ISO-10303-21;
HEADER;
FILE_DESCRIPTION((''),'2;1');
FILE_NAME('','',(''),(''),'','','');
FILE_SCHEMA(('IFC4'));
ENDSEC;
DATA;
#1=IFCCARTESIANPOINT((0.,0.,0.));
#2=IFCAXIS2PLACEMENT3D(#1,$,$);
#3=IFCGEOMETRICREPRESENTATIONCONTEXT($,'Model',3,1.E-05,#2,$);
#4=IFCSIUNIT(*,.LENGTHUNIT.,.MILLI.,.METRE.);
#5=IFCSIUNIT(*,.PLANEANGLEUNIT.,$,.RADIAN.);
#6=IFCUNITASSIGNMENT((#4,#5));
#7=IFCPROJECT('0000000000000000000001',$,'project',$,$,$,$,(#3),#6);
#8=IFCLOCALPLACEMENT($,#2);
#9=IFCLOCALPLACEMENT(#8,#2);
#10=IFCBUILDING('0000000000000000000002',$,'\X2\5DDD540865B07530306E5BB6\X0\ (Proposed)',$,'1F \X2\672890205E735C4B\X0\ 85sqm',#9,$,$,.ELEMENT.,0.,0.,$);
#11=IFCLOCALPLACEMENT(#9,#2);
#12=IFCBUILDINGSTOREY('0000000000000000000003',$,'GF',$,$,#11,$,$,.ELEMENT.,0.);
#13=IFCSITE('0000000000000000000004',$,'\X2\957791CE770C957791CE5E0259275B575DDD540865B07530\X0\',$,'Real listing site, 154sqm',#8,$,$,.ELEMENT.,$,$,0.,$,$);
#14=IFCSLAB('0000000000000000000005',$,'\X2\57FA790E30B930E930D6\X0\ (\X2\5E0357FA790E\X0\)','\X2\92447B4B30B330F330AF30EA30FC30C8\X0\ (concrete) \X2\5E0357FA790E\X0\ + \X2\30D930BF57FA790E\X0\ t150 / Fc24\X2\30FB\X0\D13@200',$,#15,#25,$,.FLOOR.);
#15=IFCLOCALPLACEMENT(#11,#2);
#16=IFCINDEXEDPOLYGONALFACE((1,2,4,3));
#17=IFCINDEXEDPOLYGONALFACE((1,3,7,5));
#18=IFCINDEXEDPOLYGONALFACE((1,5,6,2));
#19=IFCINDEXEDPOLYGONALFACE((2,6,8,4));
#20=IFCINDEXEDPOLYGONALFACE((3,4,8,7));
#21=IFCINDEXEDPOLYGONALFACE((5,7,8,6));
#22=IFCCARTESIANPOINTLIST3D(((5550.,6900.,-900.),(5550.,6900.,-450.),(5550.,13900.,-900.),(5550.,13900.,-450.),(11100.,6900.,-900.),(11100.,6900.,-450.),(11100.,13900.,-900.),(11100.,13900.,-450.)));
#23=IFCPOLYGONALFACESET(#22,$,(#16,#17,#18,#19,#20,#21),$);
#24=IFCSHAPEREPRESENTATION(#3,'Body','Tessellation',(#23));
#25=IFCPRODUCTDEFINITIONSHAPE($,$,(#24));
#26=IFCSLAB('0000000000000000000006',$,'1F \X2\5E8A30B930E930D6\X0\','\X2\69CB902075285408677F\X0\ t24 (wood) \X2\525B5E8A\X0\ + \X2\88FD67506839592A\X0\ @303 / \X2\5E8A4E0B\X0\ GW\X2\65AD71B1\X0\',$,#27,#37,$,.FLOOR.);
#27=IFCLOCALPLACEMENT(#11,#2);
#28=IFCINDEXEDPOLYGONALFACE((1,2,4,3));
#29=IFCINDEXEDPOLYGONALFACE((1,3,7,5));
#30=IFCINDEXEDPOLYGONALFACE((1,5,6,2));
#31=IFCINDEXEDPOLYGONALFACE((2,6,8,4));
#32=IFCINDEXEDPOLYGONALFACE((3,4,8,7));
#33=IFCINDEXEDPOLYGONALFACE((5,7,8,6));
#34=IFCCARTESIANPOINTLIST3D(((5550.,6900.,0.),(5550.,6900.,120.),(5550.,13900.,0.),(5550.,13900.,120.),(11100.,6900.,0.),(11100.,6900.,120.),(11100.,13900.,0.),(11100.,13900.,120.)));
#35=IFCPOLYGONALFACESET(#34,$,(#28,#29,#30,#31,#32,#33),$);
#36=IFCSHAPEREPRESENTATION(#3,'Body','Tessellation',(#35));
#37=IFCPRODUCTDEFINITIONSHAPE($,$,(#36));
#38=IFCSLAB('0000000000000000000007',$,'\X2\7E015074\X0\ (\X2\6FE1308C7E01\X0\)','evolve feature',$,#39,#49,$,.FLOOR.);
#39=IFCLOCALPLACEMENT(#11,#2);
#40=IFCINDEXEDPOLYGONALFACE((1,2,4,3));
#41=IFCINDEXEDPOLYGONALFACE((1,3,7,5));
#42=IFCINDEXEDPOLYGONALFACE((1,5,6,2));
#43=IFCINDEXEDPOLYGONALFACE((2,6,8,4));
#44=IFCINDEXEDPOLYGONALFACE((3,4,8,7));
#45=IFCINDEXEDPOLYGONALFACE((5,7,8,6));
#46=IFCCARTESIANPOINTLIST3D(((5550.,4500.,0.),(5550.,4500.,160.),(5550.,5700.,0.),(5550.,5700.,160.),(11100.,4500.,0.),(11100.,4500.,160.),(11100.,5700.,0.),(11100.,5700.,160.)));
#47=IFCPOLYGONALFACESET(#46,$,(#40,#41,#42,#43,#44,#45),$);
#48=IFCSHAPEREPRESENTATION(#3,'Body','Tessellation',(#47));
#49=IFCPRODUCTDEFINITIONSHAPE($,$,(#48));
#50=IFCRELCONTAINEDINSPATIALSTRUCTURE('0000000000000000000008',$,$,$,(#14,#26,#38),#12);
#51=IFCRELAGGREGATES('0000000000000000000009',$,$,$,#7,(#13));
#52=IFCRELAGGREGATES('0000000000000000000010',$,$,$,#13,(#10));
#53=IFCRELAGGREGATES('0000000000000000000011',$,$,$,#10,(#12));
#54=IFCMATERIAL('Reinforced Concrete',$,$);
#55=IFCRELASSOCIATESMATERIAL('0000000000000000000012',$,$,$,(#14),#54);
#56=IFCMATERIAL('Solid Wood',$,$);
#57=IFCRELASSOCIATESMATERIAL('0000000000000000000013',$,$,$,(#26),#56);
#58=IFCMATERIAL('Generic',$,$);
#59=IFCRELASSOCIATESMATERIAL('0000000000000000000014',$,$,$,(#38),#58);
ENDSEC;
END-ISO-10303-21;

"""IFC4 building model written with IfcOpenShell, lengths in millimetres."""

from ifc_helpers import new_model, si_unit, frame, frame_2d, origin, place, context, project, spatial, rectangle, extrude, material, element, save


model = new_model("IFC4")

# Units and contexts
model_context = context("Model", 3, precision=1e-05, world=origin())
ifc_project = project(units=[si_unit("LENGTHUNIT", "METRE", prefix="MILLI"), si_unit("PLANEANGLEUNIT", "RADIAN")], contexts=[model_context])

# Site, building, storey
site_placement = place(None, origin())
site = spatial("IfcSite", under=ifc_project, at=site_placement, Name="長野県長野市大字川合新田", ObjectType="Real listing site, 154sqm", CompositionType="ELEMENT", RefElevation=0.0)
building_placement = place(site_placement, origin())
building = spatial("IfcBuilding", under=site, at=building_placement, Name="川合新田の家 (Proposed)", ObjectType="1F 木造平屋 85sqm", CompositionType="ELEMENT", ElevationOfRefHeight=0.0, ElevationOfTerrain=0.0)
storey_placement = place(building_placement, origin())
storey = spatial("IfcBuildingStorey", under=building, at=storey_placement, Name="GF", CompositionType="ELEMENT", Elevation=0.0)

# Slabs
ifc_material_1 = material(Name="Reinforced Concrete")
slab_1_placement = place(storey_placement, frame((2775.0, 3450.0, -450.0)))
element("IfcSlab", 1, at=slab_1_placement, inside=storey, material=ifc_material_1, Name="基礎スラブ (布基礎)", Description="鉄筋コンクリート (concrete) 布基礎 + ベタ基礎 t150 / Fc24・D13@200", PredefinedType="FLOOR", context=model_context, shape_type="SweptSolid", body=[
    extrude(rectangle(XDim=5550.0, YDim=7000.0, at=frame_2d((2775.0, 3500.0))), frame((2775.0, 3450.0, -450.0)), (0.0, 0.0, 1.0), 450.0),
])
ifc_material_2 = material(Name="Solid Wood")
slab_2_placement = place(storey_placement, frame((2775.0, 3450.0, 0.0)))
element("IfcSlab", 2, at=slab_2_placement, inside=storey, material=ifc_material_2, Name="1F 床スラブ", Description="構造用合板 t24 (wood) 剛床 + 製材根太 @303 / 床下 GW断熱", PredefinedType="FLOOR", context=model_context, shape_type="SweptSolid", body=[
    extrude(rectangle(XDim=5550.0, YDim=7000.0, at=frame_2d((2775.0, 3500.0))), frame((2775.0, 3450.0, 0.0)), (0.0, 0.0, 1.0), 120.0),
])
ifc_material_3 = material(Name="Generic")
slab_3_placement = place(storey_placement, frame((2775.0, 2250.0, 0.0)))
element("IfcSlab", 3, at=slab_3_placement, inside=storey, material=ifc_material_3, Name="縁側 (濡れ縁)", Description="evolve feature", PredefinedType="FLOOR", context=model_context, shape_type="SweptSolid", body=[
    extrude(rectangle(XDim=5550.0, YDim=1200.0, at=frame_2d((2775.0, 600.0))), frame((2775.0, 2250.0, 0.0)), (0.0, 0.0, 1.0), 160.0),
])

save(model, "model.ifc")
